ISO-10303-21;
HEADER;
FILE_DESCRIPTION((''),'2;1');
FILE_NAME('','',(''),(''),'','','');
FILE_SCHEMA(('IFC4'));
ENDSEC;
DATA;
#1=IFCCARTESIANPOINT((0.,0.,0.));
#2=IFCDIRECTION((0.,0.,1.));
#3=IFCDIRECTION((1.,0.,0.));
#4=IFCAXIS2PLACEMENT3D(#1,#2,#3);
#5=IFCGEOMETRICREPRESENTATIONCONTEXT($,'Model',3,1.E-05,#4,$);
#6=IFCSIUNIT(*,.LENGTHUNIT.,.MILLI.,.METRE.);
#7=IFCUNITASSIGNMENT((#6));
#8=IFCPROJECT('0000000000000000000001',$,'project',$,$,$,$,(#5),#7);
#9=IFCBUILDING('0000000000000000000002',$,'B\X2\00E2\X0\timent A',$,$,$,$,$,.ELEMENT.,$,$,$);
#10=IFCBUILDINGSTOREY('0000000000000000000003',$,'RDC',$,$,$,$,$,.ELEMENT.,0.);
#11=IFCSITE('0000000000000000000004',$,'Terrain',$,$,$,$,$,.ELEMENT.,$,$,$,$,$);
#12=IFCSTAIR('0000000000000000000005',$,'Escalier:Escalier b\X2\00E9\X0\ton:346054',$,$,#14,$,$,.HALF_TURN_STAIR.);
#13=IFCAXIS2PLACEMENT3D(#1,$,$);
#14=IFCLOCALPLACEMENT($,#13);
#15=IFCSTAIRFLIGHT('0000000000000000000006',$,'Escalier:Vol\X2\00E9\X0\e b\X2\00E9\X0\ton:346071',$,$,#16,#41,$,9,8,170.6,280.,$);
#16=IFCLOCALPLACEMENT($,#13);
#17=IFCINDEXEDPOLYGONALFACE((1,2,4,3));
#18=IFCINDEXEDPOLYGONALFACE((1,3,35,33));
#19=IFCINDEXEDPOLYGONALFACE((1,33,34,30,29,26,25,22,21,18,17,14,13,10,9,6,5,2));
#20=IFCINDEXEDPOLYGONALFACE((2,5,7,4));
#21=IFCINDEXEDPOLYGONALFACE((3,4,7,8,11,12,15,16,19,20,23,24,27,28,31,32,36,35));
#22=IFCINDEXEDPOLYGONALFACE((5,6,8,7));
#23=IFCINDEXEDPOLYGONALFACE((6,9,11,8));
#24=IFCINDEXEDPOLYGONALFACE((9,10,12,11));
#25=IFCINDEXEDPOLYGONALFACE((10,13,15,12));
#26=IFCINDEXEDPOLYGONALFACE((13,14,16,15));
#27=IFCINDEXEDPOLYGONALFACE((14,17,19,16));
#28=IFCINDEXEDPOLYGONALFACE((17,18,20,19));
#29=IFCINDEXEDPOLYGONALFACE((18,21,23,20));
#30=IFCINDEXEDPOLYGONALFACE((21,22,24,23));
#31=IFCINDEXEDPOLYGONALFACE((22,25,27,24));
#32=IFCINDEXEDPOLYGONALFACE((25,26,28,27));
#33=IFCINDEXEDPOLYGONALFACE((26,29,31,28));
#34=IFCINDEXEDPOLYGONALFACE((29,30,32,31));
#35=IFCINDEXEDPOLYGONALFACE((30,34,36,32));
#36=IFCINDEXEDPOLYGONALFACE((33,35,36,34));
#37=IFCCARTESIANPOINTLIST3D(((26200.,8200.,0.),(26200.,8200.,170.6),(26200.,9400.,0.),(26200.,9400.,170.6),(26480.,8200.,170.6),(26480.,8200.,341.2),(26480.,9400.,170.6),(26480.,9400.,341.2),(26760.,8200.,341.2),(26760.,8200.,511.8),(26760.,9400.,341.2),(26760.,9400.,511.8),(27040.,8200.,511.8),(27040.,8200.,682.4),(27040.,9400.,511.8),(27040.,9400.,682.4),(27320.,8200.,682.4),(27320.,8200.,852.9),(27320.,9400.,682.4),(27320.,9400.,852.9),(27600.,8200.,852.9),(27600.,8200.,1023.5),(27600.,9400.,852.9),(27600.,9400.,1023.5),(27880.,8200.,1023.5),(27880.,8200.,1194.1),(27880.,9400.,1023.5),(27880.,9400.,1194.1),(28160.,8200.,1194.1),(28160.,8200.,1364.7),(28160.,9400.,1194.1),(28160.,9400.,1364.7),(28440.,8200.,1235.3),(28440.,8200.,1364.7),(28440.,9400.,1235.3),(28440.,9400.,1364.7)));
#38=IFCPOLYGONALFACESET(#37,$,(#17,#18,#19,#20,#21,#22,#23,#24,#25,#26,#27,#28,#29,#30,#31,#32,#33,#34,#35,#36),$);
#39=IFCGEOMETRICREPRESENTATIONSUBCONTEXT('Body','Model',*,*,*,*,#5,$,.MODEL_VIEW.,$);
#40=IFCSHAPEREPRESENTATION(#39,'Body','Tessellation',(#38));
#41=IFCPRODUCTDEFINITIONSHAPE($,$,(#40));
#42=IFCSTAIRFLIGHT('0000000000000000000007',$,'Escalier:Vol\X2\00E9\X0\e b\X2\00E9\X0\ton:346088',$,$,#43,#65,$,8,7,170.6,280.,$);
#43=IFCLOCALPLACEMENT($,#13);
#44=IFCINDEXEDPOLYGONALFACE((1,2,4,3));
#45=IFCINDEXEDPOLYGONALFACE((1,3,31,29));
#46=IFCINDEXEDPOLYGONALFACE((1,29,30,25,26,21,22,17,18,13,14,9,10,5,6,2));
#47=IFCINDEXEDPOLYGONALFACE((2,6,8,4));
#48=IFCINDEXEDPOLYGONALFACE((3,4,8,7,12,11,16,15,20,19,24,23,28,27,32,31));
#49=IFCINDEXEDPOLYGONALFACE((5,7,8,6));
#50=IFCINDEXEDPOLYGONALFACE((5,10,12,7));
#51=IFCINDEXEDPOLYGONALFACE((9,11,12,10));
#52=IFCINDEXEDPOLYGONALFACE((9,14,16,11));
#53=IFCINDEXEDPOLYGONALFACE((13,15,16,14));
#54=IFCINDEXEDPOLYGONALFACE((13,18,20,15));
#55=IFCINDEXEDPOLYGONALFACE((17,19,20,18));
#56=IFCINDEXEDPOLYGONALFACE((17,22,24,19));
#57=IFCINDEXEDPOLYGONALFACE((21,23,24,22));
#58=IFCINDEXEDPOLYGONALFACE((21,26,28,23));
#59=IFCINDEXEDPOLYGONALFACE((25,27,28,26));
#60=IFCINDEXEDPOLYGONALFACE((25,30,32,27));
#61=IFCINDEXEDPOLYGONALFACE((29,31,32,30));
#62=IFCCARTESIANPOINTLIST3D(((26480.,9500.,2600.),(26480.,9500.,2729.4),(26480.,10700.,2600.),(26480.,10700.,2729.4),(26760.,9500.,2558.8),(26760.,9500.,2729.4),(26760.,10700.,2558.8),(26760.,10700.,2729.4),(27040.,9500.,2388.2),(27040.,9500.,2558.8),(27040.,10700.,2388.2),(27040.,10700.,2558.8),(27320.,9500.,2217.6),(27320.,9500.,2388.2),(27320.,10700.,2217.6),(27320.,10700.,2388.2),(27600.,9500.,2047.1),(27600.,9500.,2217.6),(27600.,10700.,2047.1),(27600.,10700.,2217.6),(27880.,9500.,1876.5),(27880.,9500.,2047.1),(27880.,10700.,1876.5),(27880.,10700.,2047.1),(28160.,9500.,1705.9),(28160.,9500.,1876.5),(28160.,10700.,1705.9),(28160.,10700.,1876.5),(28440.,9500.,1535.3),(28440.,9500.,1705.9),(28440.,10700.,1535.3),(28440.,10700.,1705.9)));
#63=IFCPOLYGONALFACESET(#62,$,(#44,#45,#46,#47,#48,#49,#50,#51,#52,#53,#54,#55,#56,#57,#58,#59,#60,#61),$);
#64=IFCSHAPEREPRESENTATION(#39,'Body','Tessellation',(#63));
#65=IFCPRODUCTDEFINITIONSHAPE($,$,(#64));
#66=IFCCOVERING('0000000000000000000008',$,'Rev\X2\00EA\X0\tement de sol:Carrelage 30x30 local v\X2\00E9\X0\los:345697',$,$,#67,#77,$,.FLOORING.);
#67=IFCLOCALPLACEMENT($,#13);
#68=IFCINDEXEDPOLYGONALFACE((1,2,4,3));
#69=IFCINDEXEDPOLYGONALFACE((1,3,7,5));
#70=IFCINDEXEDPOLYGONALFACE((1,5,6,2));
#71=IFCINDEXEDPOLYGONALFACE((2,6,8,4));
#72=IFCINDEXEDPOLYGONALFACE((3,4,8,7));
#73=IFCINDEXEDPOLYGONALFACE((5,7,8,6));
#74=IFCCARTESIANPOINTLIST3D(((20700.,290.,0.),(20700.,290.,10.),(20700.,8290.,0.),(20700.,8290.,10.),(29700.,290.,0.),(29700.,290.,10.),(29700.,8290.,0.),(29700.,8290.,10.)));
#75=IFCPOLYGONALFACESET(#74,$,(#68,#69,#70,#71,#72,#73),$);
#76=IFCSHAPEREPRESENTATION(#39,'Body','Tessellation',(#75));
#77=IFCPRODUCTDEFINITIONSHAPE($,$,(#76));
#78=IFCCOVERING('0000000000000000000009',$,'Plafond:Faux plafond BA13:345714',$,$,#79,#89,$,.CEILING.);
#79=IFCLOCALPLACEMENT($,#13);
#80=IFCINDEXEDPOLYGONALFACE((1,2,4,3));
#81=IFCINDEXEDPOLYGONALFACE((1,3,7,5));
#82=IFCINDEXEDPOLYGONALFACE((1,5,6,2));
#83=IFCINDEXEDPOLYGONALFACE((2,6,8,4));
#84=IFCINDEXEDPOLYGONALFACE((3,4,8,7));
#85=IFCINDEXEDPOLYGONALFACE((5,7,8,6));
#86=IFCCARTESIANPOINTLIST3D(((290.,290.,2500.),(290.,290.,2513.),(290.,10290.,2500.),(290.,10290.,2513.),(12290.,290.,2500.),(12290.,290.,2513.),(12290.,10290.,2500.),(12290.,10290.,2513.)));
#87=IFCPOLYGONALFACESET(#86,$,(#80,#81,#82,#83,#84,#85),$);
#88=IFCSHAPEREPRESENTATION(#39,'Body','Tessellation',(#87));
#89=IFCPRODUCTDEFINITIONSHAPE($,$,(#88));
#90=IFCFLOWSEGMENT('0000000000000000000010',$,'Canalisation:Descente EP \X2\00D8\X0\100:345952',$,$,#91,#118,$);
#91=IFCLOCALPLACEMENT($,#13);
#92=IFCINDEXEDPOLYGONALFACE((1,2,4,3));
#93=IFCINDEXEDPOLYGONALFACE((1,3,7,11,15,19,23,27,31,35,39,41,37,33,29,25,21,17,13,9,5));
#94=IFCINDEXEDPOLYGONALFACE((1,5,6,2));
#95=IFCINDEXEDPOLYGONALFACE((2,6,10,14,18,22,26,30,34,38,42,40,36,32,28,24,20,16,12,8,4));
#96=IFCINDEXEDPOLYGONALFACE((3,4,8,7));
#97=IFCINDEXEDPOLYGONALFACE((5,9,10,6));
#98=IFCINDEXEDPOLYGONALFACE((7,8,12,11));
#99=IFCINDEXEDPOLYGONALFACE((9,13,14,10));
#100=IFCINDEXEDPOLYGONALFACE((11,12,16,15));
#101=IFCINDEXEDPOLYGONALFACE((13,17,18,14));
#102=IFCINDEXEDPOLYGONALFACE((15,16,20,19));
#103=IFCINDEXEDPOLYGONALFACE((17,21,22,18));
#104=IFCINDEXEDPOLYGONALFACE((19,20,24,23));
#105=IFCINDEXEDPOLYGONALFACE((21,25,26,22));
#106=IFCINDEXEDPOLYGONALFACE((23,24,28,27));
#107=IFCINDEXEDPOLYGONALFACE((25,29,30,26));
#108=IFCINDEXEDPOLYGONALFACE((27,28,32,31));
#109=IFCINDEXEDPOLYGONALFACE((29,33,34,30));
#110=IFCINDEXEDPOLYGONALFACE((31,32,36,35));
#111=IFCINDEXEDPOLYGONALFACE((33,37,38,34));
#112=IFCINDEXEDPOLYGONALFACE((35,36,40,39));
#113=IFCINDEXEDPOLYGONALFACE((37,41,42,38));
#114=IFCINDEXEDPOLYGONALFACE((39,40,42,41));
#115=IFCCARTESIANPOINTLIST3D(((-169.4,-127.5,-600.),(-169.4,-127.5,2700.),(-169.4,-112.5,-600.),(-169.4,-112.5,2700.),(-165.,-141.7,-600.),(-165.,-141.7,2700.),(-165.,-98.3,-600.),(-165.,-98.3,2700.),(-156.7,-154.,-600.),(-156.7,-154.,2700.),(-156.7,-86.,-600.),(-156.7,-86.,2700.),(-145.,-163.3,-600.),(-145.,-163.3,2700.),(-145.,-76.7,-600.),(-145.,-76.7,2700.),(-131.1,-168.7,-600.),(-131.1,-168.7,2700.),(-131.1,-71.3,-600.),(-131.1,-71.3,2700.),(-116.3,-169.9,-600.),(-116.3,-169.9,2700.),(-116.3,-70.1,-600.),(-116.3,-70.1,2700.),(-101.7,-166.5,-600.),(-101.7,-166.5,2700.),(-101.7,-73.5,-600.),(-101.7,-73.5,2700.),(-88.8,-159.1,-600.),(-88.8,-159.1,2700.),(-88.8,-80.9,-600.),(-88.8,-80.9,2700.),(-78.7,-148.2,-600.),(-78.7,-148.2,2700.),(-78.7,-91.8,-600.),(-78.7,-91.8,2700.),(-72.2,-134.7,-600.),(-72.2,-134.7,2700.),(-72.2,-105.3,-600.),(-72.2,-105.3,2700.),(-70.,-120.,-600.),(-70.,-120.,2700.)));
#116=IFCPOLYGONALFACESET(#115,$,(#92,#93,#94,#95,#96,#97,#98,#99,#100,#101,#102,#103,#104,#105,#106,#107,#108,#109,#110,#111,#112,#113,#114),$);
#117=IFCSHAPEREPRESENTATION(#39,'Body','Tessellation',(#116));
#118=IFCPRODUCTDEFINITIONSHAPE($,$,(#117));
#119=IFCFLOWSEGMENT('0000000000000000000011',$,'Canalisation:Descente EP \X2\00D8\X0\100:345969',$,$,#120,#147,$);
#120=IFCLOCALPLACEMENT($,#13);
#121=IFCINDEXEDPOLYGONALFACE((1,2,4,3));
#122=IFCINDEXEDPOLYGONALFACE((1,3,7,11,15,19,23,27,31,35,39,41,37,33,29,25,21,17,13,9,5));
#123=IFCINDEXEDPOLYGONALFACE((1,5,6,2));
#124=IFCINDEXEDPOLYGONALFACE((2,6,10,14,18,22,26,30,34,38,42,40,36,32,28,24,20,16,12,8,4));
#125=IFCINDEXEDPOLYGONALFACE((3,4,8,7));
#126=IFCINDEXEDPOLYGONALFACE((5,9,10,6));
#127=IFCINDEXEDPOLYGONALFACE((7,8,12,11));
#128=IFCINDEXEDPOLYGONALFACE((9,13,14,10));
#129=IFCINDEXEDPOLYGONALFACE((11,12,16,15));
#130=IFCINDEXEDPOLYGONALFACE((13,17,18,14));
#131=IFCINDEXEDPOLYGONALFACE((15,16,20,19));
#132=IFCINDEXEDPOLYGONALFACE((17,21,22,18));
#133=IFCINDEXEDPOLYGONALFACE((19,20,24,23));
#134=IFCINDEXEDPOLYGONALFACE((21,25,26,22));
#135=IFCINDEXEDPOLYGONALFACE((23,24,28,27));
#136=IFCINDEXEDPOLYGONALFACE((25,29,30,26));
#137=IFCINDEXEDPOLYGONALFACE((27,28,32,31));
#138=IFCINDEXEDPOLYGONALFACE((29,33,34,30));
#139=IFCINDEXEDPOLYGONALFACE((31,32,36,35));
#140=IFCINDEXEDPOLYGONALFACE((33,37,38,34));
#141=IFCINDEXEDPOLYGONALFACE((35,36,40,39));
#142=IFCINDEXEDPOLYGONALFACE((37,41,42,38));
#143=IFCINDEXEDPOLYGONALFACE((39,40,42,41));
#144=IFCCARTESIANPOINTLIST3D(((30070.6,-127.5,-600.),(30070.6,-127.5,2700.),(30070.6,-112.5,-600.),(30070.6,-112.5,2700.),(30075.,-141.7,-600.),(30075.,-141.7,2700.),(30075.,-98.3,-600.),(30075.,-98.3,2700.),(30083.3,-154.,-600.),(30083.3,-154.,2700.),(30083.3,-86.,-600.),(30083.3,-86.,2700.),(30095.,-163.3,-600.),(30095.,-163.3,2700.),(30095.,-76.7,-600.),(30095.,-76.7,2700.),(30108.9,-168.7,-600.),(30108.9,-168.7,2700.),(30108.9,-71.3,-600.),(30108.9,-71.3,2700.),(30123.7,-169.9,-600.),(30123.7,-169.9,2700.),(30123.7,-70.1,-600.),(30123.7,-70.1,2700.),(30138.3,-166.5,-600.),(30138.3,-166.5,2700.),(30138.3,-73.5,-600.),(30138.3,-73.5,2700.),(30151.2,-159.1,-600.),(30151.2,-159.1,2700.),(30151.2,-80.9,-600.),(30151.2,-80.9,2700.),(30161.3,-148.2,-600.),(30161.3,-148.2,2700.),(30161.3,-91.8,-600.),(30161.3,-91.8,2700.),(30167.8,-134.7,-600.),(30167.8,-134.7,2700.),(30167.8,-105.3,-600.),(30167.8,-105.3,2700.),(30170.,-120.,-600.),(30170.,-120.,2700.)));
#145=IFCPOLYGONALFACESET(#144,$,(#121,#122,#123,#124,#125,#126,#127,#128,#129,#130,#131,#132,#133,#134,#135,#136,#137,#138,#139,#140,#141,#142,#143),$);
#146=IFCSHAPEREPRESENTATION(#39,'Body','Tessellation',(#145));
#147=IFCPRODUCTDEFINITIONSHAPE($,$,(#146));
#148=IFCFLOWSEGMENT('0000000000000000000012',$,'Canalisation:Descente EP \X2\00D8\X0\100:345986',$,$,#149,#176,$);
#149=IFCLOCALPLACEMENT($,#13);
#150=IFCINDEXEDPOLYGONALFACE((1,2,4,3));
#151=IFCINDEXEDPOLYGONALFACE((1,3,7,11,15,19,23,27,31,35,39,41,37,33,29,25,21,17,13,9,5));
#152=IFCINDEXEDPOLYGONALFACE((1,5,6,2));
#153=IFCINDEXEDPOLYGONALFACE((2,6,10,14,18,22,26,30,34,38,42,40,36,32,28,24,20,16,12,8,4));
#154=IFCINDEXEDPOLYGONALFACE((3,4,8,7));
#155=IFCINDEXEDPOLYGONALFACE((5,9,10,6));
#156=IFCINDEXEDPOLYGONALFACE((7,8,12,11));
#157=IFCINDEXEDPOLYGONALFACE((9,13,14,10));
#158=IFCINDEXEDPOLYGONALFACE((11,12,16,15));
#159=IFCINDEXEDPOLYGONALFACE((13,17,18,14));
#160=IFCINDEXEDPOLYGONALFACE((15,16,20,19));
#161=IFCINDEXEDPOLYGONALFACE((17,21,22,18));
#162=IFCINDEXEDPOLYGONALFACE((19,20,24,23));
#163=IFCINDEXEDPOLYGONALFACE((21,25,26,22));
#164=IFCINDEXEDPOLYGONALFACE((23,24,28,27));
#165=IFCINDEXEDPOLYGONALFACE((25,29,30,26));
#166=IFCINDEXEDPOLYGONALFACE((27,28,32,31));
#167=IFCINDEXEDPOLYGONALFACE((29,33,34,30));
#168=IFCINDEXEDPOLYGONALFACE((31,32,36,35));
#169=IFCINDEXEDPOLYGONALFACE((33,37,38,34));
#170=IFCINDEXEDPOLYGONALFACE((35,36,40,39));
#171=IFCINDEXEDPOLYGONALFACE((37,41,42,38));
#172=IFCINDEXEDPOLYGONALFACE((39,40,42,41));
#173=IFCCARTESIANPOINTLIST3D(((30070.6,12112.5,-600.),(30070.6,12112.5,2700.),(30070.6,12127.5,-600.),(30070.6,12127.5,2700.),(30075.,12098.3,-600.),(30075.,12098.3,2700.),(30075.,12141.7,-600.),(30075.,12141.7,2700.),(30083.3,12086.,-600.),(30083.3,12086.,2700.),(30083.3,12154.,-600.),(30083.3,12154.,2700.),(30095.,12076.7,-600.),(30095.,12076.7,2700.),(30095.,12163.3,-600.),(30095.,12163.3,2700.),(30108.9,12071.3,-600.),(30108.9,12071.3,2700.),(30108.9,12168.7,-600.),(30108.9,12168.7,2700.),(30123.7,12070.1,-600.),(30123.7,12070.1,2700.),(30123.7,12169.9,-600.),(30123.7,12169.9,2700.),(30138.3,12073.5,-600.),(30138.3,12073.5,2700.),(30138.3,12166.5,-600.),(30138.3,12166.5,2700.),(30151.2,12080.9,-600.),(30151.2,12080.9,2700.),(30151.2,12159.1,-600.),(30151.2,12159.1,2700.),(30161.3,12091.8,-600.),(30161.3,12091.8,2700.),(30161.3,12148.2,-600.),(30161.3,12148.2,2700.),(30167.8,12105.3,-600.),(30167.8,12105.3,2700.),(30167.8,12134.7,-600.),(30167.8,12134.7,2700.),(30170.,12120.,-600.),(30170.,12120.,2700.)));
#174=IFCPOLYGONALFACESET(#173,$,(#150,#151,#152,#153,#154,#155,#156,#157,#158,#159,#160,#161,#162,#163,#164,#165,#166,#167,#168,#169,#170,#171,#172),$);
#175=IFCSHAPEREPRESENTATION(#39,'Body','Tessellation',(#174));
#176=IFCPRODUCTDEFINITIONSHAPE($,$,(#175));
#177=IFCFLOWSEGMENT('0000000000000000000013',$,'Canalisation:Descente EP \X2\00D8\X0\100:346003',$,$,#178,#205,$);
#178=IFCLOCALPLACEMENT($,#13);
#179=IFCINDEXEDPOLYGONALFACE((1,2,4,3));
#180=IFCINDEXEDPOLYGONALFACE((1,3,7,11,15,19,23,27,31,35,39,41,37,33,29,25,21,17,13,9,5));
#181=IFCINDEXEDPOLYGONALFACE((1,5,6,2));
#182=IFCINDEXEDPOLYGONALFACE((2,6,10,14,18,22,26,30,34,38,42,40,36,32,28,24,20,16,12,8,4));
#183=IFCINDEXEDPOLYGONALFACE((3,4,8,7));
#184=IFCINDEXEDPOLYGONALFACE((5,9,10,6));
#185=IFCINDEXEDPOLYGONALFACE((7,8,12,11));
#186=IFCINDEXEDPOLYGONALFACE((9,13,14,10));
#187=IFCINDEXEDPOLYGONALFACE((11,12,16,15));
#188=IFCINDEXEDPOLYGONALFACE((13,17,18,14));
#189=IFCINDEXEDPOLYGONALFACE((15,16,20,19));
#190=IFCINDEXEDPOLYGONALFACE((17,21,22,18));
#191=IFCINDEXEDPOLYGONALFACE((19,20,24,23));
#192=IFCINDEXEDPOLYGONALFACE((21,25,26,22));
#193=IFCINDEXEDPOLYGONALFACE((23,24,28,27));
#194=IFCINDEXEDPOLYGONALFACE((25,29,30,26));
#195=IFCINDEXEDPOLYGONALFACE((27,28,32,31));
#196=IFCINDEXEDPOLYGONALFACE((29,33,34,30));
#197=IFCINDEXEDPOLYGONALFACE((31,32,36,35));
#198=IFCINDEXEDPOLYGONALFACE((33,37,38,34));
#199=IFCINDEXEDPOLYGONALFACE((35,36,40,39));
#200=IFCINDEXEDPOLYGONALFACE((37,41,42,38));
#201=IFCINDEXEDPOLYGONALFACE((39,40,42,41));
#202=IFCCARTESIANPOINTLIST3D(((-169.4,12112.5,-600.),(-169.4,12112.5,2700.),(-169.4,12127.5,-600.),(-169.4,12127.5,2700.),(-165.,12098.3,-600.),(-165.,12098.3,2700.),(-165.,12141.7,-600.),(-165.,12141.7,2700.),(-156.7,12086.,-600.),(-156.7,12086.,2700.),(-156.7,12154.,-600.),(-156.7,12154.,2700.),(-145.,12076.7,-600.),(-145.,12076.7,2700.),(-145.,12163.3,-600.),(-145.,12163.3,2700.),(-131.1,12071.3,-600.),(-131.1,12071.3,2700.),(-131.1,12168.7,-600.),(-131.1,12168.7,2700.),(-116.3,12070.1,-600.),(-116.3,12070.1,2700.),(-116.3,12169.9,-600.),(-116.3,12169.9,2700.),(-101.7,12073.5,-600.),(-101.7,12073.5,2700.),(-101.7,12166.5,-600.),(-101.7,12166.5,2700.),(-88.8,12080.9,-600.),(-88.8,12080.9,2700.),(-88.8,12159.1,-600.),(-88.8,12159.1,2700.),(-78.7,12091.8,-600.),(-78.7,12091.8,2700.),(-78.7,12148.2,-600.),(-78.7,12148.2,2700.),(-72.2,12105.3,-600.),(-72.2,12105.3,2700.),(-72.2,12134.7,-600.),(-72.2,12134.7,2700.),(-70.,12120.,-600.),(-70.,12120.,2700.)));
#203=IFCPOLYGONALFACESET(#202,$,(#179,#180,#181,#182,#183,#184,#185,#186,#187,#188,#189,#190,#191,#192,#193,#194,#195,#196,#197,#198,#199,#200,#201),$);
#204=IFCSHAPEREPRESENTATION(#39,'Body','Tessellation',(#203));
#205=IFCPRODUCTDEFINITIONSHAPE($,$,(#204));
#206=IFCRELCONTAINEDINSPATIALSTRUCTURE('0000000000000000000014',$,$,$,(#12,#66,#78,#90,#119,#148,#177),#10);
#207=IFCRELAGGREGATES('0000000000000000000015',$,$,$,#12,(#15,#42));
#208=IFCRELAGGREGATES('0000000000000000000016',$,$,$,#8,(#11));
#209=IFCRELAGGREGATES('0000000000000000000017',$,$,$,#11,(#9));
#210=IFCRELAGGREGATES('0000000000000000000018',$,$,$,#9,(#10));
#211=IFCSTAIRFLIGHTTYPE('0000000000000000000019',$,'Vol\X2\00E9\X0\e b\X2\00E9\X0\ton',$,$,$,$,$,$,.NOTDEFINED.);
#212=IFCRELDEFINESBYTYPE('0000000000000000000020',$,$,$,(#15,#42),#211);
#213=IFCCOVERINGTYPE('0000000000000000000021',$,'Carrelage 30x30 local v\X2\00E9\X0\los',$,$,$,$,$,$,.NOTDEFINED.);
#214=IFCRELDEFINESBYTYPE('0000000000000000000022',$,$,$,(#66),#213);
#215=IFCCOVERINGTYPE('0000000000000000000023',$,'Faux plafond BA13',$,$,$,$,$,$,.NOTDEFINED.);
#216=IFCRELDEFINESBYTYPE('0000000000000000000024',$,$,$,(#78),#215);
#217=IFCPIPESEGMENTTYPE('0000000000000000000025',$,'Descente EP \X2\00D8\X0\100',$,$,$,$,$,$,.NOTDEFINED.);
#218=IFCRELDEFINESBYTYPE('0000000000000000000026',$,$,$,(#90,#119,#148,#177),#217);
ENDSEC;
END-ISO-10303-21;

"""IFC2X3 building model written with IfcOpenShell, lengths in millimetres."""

from ifc_helpers import new_model, si_unit, frame, frame_2d, origin_with_axes, origin_2d, place, context, subcontext, project, spatial, polyline, rectangle, circle, outline, extrude, type_object, element, aggregate, save


model = new_model("IFC2X3")

# Units and contexts
model_context = context("Model", 3, precision=1e-05, world=origin_with_axes())
body_context = subcontext(model_context, "Body", "Model", "MODEL_VIEW")
ifc_project = project(units=[si_unit("LENGTHUNIT", "METRE", prefix="MILLI")], contexts=[model_context])

# Site, building, storey
site = spatial("IfcSite", under=ifc_project, Name="Terrain", CompositionType="ELEMENT")
building = spatial("IfcBuilding", under=site, Name="Bâtiment A", CompositionType="ELEMENT")
storey = spatial("IfcBuildingStorey", under=building, Name="RDC", CompositionType="ELEMENT", Elevation=0.0)

# Stair, stair flights
stair = element("IfcStair", 1, inside=storey, Name="Escalier:Escalier béton:346054", ShapeType="HALF_TURN_STAIR")
stair_flight_type = type_object("IfcStairFlightType", Name="Volée béton", PredefinedType="NOTDEFINED")
stair_flight_1_placement = place(None, origin_with_axes())
stair_flight_1 = element("IfcStairFlight", 2, at=stair_flight_1_placement, type_object=stair_flight_type, Name="Escalier:Volée béton:346071", NumberOfRiser=9, NumberOfTreads=8, RiserHeight=170.6, TreadLength=280.0, context=body_context, shape_type="SweptSolid", body=[
    extrude(outline(polyline([(0.0, 0.0), (0.0, 170.6), (280.0, 170.6), (280.0, 341.2), (560.0, 341.2), (560.0, 511.8), (840.0, 511.8), (840.0, 682.4), (1120.0, 682.4), (1120.0, 852.9), (1400.0, 852.9), (1400.0, 1023.5), (1680.0, 1023.5), (1680.0, 1194.1), (1960.0, 1194.1), (1960.0, 1364.7), (2240.0, 1364.7), (2240.0, 1535.3), (2240.0, 1235.3), (0.0, 0.0)])), frame((26200.0, 9400.0, 0.0), z_axis=(0.0, -1.0, 0.0), x_axis=(1.0, 0.0, 0.0)), (0.0, 0.0, 1.0), 1200.0),
])
stair_flight_2_placement = place(None, origin_with_axes())
stair_flight_2 = element("IfcStairFlight", 3, at=stair_flight_2_placement, type_object=stair_flight_type, Name="Escalier:Volée béton:346088", NumberOfRiser=8, NumberOfTreads=7, RiserHeight=170.6, TreadLength=280.0, context=body_context, shape_type="SweptSolid", body=[
    extrude(outline(polyline([(0.0, 0.0), (0.0, 170.6), (280.0, 170.6), (280.0, 341.2), (560.0, 341.2), (560.0, 511.8), (840.0, 511.8), (840.0, 682.4), (1120.0, 682.4), (1120.0, 852.9), (1400.0, 852.9), (1400.0, 1023.5), (1680.0, 1023.5), (1680.0, 1194.1), (1960.0, 1194.1), (1960.0, 1364.7), (1960.0, 1064.7), (0.0, 0.0)])), frame((28440.0, 9500.0, 1535.3), z_axis=(0.0, 1.0, 0.0), x_axis=(-1.0, 0.0, 0.0)), (0.0, 0.0, 1.0), 1200.0),
])
aggregate(stair, [stair_flight_1, stair_flight_2])

# Coverings
covering_type_1 = type_object("IfcCoveringType", Name="Carrelage 30x30 local vélos", PredefinedType="NOTDEFINED")
covering_1_placement = place(None, origin_with_axes())
element("IfcCovering", 4, at=covering_1_placement, inside=storey, type_object=covering_type_1, Name="Revêtement de sol:Carrelage 30x30 local vélos:345697", PredefinedType="FLOORING", context=body_context, shape_type="SweptSolid", body=[
    extrude(rectangle(XDim=9000.0, YDim=8000.0, at=frame_2d((25200.0, 4290.0))), origin_with_axes(), (0.0, 0.0, 1.0), 10.0),
])
covering_type_2 = type_object("IfcCoveringType", Name="Faux plafond BA13", PredefinedType="NOTDEFINED")
covering_2_placement = place(None, origin_with_axes())
element("IfcCovering", 5, at=covering_2_placement, inside=storey, type_object=covering_type_2, Name="Plafond:Faux plafond BA13:345714", PredefinedType="CEILING", context=body_context, shape_type="SweptSolid", body=[
    extrude(rectangle(XDim=12000.0, YDim=10000.0, at=frame_2d((6290.0, 5290.0))), frame((0.0, 0.0, 2500.0), z_axis=(0.0, 0.0, 1.0), x_axis=(1.0, 0.0, 0.0)), (0.0, 0.0, 1.0), 13.0),
])

# Flow segments
pipe_segment_type_1 = type_object("IfcPipeSegmentType", Name="Descente EP Ø100", PredefinedType="NOTDEFINED")
flow_segment_1_placement = place(None, origin_with_axes())
element("IfcFlowSegment", 6, at=flow_segment_1_placement, inside=storey, type_object=pipe_segment_type_1, Name="Canalisation:Descente EP Ø100:345952", context=body_context, shape_type="SweptSolid", body=[
    extrude(circle(Radius=50.0, at=origin_2d()), frame((-120.0, -120.0, -600.0), z_axis=(0.0, 0.0, 1.0), x_axis=(1.0, 0.0, 0.0)), (0.0, 0.0, 1.0), 3300.0),
])
flow_segment_2_placement = place(None, origin_with_axes())
element("IfcFlowSegment", 7, at=flow_segment_2_placement, inside=storey, type_object=pipe_segment_type_1, Name="Canalisation:Descente EP Ø100:345969", context=body_context, shape_type="SweptSolid", body=[
    extrude(circle(Radius=50.0, at=origin_2d()), frame((30120.0, -120.0, -600.0), z_axis=(0.0, 0.0, 1.0), x_axis=(1.0, 0.0, 0.0)), (0.0, 0.0, 1.0), 3300.0),
])
flow_segment_3_placement = place(None, origin_with_axes())
element("IfcFlowSegment", 8, at=flow_segment_3_placement, inside=storey, type_object=pipe_segment_type_1, Name="Canalisation:Descente EP Ø100:345986", context=body_context, shape_type="SweptSolid", body=[
    extrude(circle(Radius=50.0, at=origin_2d()), frame((30120.0, 12120.0, -600.0), z_axis=(0.0, 0.0, 1.0), x_axis=(1.0, 0.0, 0.0)), (0.0, 0.0, 1.0), 3300.0),
])
flow_segment_4_placement = place(None, origin_with_axes())
element("IfcFlowSegment", 9, at=flow_segment_4_placement, inside=storey, type_object=pipe_segment_type_1, Name="Canalisation:Descente EP Ø100:346003", context=body_context, shape_type="SweptSolid", body=[
    extrude(circle(Radius=50.0, at=origin_2d()), frame((-120.0, 12120.0, -600.0), z_axis=(0.0, 0.0, 1.0), x_axis=(1.0, 0.0, 0.0)), (0.0, 0.0, 1.0), 3300.0),
])

save(model, "model.ifc")
